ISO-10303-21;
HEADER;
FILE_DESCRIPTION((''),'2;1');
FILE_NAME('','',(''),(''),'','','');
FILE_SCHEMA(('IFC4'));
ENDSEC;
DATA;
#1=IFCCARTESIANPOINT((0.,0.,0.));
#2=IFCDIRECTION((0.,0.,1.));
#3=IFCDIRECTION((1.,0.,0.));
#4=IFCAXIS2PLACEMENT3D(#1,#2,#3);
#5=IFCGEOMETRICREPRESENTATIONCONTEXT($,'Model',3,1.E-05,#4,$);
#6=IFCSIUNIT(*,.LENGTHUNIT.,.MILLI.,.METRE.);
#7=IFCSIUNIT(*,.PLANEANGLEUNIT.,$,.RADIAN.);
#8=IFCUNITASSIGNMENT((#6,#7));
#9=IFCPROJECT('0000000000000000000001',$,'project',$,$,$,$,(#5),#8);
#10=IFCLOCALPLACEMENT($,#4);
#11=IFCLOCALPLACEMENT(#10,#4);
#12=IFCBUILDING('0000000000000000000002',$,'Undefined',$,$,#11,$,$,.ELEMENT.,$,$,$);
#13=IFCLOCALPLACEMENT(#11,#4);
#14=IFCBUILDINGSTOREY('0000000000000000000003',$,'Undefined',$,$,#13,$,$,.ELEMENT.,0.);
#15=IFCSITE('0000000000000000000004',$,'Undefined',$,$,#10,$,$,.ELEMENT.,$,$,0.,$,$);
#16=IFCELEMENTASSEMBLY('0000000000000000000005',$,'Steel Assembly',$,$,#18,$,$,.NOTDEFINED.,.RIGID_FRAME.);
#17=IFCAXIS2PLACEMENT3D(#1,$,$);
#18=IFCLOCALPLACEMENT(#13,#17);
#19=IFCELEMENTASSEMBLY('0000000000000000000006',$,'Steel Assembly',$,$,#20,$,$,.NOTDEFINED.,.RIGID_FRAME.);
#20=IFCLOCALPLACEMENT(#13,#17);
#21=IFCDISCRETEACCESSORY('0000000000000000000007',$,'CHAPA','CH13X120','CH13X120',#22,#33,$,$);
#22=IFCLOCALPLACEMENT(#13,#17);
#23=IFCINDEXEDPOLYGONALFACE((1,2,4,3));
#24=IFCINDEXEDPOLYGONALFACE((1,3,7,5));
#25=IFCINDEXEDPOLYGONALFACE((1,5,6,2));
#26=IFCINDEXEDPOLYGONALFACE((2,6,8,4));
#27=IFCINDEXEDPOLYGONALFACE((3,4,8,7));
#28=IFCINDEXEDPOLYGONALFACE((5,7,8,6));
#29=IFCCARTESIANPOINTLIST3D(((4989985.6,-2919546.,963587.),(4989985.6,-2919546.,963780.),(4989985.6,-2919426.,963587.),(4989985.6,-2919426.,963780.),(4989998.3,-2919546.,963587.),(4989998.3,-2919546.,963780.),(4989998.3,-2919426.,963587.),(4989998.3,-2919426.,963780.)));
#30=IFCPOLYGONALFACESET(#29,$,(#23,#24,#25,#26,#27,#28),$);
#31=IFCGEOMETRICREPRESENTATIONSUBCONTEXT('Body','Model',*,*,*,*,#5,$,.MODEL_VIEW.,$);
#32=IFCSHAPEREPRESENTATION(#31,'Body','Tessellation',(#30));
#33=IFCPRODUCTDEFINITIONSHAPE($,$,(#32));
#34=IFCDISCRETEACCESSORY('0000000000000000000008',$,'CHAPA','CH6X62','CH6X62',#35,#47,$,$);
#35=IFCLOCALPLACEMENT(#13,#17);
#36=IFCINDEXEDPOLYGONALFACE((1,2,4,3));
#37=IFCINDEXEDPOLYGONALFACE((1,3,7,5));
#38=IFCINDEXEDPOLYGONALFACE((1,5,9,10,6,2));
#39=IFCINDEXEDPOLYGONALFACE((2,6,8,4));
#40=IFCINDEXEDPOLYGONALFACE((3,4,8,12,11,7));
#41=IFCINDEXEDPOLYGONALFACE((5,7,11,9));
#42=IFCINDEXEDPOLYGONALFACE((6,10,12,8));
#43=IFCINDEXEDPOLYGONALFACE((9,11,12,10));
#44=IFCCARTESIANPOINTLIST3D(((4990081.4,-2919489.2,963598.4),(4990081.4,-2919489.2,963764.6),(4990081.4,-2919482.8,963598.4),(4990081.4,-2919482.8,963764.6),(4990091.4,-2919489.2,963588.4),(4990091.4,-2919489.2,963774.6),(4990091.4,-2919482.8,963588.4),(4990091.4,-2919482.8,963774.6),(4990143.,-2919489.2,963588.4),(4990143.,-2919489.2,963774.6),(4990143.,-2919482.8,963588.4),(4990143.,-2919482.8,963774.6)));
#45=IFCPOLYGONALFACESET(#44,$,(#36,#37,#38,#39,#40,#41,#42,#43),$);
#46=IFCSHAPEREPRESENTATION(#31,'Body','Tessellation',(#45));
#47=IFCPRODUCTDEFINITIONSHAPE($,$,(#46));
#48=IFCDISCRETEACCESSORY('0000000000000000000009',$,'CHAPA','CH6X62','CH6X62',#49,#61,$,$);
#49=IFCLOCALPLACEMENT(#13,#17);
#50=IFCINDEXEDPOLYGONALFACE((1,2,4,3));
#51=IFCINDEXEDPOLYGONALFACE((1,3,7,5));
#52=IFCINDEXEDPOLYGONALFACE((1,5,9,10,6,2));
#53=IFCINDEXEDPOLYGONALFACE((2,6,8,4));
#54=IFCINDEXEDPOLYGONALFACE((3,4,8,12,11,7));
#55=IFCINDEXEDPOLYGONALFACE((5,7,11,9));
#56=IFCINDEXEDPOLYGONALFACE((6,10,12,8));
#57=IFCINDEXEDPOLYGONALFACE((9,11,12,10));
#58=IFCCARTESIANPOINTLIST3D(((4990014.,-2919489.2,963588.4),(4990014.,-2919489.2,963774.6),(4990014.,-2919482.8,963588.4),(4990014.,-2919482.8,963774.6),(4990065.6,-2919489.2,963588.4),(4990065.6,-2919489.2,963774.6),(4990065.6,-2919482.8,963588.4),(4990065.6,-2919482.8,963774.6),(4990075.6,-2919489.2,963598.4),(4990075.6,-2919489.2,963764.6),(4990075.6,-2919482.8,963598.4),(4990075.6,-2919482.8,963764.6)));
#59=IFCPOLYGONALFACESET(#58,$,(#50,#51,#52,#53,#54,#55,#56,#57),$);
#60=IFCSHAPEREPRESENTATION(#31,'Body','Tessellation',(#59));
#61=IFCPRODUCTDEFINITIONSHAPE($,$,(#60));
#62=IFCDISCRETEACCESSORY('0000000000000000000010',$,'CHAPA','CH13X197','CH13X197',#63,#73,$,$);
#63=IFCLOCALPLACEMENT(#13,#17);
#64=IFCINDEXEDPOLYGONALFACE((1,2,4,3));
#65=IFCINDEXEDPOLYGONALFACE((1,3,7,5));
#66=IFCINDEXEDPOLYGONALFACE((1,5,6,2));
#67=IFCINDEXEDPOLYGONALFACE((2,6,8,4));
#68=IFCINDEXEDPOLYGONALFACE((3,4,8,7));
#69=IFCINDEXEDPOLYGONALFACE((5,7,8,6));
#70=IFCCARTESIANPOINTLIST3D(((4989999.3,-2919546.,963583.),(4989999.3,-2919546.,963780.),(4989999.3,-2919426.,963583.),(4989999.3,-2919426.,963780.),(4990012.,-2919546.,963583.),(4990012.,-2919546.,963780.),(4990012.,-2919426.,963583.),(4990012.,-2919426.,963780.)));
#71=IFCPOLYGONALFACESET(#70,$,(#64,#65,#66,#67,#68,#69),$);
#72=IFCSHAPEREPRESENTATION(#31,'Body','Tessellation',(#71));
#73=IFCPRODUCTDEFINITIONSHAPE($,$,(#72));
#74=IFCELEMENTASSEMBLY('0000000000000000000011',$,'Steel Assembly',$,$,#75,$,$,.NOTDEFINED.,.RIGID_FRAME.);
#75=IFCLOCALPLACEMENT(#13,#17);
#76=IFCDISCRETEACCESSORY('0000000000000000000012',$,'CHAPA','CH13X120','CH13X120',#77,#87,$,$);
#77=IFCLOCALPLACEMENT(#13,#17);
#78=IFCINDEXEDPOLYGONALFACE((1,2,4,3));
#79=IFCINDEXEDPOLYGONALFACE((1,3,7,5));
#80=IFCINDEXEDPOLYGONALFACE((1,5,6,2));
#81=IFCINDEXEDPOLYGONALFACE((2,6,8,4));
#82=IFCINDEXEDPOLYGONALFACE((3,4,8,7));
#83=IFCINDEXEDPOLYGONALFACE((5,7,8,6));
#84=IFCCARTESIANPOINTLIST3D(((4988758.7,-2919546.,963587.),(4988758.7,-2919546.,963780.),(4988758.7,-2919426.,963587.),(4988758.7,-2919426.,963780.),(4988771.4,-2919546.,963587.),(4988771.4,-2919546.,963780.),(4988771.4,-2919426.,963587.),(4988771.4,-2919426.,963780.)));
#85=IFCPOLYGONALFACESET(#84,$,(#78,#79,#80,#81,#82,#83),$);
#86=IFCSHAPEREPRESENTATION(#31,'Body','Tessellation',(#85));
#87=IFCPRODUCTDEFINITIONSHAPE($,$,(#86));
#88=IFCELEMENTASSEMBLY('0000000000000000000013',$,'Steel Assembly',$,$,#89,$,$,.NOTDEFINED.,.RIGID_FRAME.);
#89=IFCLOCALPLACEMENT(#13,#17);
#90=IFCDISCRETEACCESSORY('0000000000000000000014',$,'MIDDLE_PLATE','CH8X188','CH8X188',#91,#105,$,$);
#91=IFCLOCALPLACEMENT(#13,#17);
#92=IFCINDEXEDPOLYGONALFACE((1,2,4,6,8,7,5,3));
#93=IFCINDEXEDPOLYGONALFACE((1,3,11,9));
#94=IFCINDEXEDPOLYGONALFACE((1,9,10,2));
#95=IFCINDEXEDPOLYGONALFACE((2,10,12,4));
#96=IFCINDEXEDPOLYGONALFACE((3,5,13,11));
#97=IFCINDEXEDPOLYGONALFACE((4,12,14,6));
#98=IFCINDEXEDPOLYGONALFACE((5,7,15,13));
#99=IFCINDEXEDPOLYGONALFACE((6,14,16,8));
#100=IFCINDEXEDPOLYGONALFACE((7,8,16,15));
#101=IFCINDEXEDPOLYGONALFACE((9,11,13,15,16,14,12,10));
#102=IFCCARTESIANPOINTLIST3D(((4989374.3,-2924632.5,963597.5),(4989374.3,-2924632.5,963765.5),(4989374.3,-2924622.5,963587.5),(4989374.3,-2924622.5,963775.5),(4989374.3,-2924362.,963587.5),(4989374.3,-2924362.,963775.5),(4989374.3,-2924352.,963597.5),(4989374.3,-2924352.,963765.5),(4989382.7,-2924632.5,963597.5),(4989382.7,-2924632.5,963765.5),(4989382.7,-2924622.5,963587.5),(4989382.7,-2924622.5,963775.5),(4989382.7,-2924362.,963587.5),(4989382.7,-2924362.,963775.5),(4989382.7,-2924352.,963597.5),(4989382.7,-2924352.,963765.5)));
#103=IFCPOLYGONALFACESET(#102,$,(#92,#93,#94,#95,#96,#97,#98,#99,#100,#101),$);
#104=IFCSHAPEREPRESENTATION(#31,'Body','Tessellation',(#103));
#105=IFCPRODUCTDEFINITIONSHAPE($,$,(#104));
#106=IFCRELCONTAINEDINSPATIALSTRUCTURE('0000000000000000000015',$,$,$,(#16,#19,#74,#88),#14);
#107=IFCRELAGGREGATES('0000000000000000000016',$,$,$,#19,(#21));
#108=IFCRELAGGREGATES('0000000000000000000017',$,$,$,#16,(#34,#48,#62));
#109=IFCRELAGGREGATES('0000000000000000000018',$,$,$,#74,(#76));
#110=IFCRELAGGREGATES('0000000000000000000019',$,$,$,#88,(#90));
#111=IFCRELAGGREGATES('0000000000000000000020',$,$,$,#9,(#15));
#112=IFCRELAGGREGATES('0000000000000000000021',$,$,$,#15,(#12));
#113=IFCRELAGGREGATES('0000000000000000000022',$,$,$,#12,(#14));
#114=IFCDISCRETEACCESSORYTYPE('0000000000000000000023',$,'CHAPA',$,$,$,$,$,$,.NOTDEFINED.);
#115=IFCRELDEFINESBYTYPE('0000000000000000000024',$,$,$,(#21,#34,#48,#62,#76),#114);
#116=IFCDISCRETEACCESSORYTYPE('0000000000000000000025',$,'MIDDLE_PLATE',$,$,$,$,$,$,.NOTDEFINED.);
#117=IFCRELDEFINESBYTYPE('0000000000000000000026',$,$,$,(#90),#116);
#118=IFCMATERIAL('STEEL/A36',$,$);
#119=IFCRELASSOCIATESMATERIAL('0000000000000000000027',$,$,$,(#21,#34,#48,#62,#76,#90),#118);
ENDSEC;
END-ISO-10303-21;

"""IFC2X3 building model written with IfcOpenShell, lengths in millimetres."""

from ifc_helpers import new_model, si_unit, frame, origin_with_axes, place, context, subcontext, project, spatial, polyline, outline, extrude, material, type_object, element, aggregate, save


model = new_model("IFC2X3")

# Units and contexts
model_context = context("Model", 3, precision=1e-05, world=origin_with_axes())
body_context = subcontext(model_context, "Body", "Model", "MODEL_VIEW")
ifc_project = project(units=[si_unit("LENGTHUNIT", "METRE", prefix="MILLI"), si_unit("PLANEANGLEUNIT", "RADIAN")], contexts=[model_context])

# Site, building, storey
site_placement = place(None, origin_with_axes())
site = spatial("IfcSite", under=ifc_project, at=site_placement, Name="Undefined", CompositionType="ELEMENT", RefElevation=0.0)
building_placement = place(site_placement, origin_with_axes())
building = spatial("IfcBuilding", under=site, at=building_placement, Name="Undefined", CompositionType="ELEMENT")
storey_placement = place(building_placement, origin_with_axes())
storey = spatial("IfcBuildingStorey", under=building, at=storey_placement, Name="Undefined", CompositionType="ELEMENT", Elevation=0.0)

# Shared definitions
ifc_material_1 = material(Name="STEEL/A36")
discrete_accessory_type_1 = type_object("IfcDiscreteAccessoryType", Name="CHAPA")

# Element assembly
assembly_1_placement = place(storey_placement, origin_with_axes())
assembly_1 = element("IfcElementAssembly", 1, at=assembly_1_placement, inside=storey, Name="Steel Assembly", AssemblyPlace="NOTDEFINED", PredefinedType="RIGID_FRAME")

# Element assembly
assembly_2_placement = place(storey_placement, origin_with_axes())
assembly_2 = element("IfcElementAssembly", 2, at=assembly_2_placement, inside=storey, Name="Steel Assembly", AssemblyPlace="NOTDEFINED", PredefinedType="RIGID_FRAME")

# Discrete accessories
discrete_accessory_1_placement = place(assembly_2_placement, frame((4989991.9, -2919486.0, 963780.0), z_axis=(-1.0, 0.0, 0.0), x_axis=(0.0, 0.0, -1.0)))
discrete_accessory_1 = element("IfcDiscreteAccessory", 3, at=discrete_accessory_1_placement, type_object=discrete_accessory_type_1, material=ifc_material_1, Name="CHAPA", Description="CH13X120", ObjectType="CH13X120", context=body_context, shape_type="SweptSolid", body=[
    extrude(outline(polyline([(193.0, 60.0), (193.0, -60.0), (0.0, -60.0), (0.0, 60.0), (193.0, 60.0)])), frame((0.0, 0.0, -6.3), z_axis=(0.0, 0.0, 1.0), x_axis=(1.0, 0.0, 0.0)), (0.0, 0.0, 1.0), 12.7),
])
aggregate(assembly_2, [discrete_accessory_1])
discrete_accessory_2_placement = place(assembly_1_placement, frame((4990081.4, -2919486.0, 963774.6), z_axis=(0.0, 1.0, 0.0), x_axis=(1.0, 0.0, 0.0)))
discrete_accessory_2 = element("IfcDiscreteAccessory", 4, at=discrete_accessory_2_placement, type_object=discrete_accessory_type_1, material=ifc_material_1, Name="CHAPA", Description="CH6X62", ObjectType="CH6X62", context=body_context, shape_type="SweptSolid", body=[
    extrude(outline(polyline([(0.0, 10.0), (10.0, 0.0), (61.6, 0.0), (61.6, 186.2), (10.0, 186.2), (0.0, 176.2), (0.0, 10.0)])), frame((0.0, 0.0, -3.2), z_axis=(0.0, 0.0, 1.0), x_axis=(1.0, 0.0, 0.0)), (0.0, 0.0, 1.0), 6.4),
])
discrete_accessory_3_placement = place(assembly_1_placement, frame((4990075.6, -2919486.0, 963774.6), z_axis=(0.0, -1.0, 0.0), x_axis=(-1.0, 0.0, 0.0)))
discrete_accessory_3 = element("IfcDiscreteAccessory", 5, at=discrete_accessory_3_placement, type_object=discrete_accessory_type_1, material=ifc_material_1, Name="CHAPA", Description="CH6X62", ObjectType="CH6X62", context=body_context, shape_type="SweptSolid", body=[
    extrude(outline(polyline([(0.0, 10.0), (10.0, 0.0), (61.6, 0.0), (61.6, 186.2), (10.0, 186.2), (0.0, 176.2), (0.0, 10.0)])), frame((0.0, 0.0, -3.2), z_axis=(0.0, 0.0, 1.0), x_axis=(1.0, 0.0, 0.0)), (0.0, 0.0, 1.0), 6.4),
])
discrete_accessory_4_placement = place(assembly_1_placement, frame((4990005.6, -2919486.0, 963780.0), z_axis=(-1.0, 0.0, 0.0), x_axis=(0.0, 0.0, -1.0)))
discrete_accessory_4 = element("IfcDiscreteAccessory", 6, at=discrete_accessory_4_placement, type_object=discrete_accessory_type_1, material=ifc_material_1, Name="CHAPA", Description="CH13X197", ObjectType="CH13X197", context=body_context, shape_type="SweptSolid", body=[
    extrude(outline(polyline([(197.0, 60.0), (197.0, -60.0), (0.0, -60.0), (0.0, 60.0), (197.0, 60.0)])), frame((0.0, 0.0, -6.3), z_axis=(0.0, 0.0, 1.0), x_axis=(1.0, 0.0, 0.0)), (0.0, 0.0, 1.0), 12.7),
])
aggregate(assembly_1, [discrete_accessory_2, discrete_accessory_3, discrete_accessory_4])

# Element assemblies, discrete accessories
assembly_3_placement = place(storey_placement, origin_with_axes())
assembly_3 = element("IfcElementAssembly", 7, at=assembly_3_placement, inside=storey, Name="Steel Assembly", AssemblyPlace="NOTDEFINED", PredefinedType="RIGID_FRAME")
discrete_accessory_5_placement = place(assembly_3_placement, frame((4988765.0, -2919486.0, 963780.0), z_axis=(1.0, 0.0, 0.0), x_axis=(0.0, 0.0, -1.0)))
discrete_accessory_5 = element("IfcDiscreteAccessory", 8, at=discrete_accessory_5_placement, type_object=discrete_accessory_type_1, material=ifc_material_1, Name="CHAPA", Description="CH13X120", ObjectType="CH13X120", context=body_context, shape_type="SweptSolid", body=[
    extrude(outline(polyline([(193.0, -60.0), (0.0, -60.0), (0.0, 60.0), (193.0, 60.0), (193.0, -60.0)])), frame((0.0, 0.0, -6.3), z_axis=(0.0, 0.0, 1.0), x_axis=(1.0, 0.0, 0.0)), (0.0, 0.0, 1.0), 12.7),
])
aggregate(assembly_3, [discrete_accessory_5])
assembly_4_placement = place(storey_placement, origin_with_axes())
assembly_4 = element("IfcElementAssembly", 9, at=assembly_4_placement, inside=storey, Name="Steel Assembly", AssemblyPlace="NOTDEFINED", PredefinedType="RIGID_FRAME")
discrete_accessory_type_2 = type_object("IfcDiscreteAccessoryType", Name="MIDDLE_PLATE")
discrete_accessory_6_placement = place(assembly_4_placement, frame((4989378.5, -2924352.0, 963775.5), z_axis=(1.0, 0.0, 0.0), x_axis=(0.0, -1.0, 0.0)))
discrete_accessory_6 = element("IfcDiscreteAccessory", 10, at=discrete_accessory_6_placement, type_object=discrete_accessory_type_2, material=ifc_material_1, Name="MIDDLE_PLATE", Description="CH8X188", ObjectType="CH8X188", context=body_context, shape_type="SweptSolid", body=[
    extrude(outline(polyline([(0.0, 10.0), (10.0, 0.0), (270.5, 0.0), (280.5, 10.0), (280.5, 178.0), (270.5, 188.0), (10.0, 188.0), (0.0, 178.0), (0.0, 10.0)])), frame((0.0, 0.0, -4.2), z_axis=(0.0, 0.0, 1.0), x_axis=(1.0, 0.0, 0.0)), (0.0, 0.0, 1.0), 8.4),
])
aggregate(assembly_4, [discrete_accessory_6])

save(model, "model.ifc")
